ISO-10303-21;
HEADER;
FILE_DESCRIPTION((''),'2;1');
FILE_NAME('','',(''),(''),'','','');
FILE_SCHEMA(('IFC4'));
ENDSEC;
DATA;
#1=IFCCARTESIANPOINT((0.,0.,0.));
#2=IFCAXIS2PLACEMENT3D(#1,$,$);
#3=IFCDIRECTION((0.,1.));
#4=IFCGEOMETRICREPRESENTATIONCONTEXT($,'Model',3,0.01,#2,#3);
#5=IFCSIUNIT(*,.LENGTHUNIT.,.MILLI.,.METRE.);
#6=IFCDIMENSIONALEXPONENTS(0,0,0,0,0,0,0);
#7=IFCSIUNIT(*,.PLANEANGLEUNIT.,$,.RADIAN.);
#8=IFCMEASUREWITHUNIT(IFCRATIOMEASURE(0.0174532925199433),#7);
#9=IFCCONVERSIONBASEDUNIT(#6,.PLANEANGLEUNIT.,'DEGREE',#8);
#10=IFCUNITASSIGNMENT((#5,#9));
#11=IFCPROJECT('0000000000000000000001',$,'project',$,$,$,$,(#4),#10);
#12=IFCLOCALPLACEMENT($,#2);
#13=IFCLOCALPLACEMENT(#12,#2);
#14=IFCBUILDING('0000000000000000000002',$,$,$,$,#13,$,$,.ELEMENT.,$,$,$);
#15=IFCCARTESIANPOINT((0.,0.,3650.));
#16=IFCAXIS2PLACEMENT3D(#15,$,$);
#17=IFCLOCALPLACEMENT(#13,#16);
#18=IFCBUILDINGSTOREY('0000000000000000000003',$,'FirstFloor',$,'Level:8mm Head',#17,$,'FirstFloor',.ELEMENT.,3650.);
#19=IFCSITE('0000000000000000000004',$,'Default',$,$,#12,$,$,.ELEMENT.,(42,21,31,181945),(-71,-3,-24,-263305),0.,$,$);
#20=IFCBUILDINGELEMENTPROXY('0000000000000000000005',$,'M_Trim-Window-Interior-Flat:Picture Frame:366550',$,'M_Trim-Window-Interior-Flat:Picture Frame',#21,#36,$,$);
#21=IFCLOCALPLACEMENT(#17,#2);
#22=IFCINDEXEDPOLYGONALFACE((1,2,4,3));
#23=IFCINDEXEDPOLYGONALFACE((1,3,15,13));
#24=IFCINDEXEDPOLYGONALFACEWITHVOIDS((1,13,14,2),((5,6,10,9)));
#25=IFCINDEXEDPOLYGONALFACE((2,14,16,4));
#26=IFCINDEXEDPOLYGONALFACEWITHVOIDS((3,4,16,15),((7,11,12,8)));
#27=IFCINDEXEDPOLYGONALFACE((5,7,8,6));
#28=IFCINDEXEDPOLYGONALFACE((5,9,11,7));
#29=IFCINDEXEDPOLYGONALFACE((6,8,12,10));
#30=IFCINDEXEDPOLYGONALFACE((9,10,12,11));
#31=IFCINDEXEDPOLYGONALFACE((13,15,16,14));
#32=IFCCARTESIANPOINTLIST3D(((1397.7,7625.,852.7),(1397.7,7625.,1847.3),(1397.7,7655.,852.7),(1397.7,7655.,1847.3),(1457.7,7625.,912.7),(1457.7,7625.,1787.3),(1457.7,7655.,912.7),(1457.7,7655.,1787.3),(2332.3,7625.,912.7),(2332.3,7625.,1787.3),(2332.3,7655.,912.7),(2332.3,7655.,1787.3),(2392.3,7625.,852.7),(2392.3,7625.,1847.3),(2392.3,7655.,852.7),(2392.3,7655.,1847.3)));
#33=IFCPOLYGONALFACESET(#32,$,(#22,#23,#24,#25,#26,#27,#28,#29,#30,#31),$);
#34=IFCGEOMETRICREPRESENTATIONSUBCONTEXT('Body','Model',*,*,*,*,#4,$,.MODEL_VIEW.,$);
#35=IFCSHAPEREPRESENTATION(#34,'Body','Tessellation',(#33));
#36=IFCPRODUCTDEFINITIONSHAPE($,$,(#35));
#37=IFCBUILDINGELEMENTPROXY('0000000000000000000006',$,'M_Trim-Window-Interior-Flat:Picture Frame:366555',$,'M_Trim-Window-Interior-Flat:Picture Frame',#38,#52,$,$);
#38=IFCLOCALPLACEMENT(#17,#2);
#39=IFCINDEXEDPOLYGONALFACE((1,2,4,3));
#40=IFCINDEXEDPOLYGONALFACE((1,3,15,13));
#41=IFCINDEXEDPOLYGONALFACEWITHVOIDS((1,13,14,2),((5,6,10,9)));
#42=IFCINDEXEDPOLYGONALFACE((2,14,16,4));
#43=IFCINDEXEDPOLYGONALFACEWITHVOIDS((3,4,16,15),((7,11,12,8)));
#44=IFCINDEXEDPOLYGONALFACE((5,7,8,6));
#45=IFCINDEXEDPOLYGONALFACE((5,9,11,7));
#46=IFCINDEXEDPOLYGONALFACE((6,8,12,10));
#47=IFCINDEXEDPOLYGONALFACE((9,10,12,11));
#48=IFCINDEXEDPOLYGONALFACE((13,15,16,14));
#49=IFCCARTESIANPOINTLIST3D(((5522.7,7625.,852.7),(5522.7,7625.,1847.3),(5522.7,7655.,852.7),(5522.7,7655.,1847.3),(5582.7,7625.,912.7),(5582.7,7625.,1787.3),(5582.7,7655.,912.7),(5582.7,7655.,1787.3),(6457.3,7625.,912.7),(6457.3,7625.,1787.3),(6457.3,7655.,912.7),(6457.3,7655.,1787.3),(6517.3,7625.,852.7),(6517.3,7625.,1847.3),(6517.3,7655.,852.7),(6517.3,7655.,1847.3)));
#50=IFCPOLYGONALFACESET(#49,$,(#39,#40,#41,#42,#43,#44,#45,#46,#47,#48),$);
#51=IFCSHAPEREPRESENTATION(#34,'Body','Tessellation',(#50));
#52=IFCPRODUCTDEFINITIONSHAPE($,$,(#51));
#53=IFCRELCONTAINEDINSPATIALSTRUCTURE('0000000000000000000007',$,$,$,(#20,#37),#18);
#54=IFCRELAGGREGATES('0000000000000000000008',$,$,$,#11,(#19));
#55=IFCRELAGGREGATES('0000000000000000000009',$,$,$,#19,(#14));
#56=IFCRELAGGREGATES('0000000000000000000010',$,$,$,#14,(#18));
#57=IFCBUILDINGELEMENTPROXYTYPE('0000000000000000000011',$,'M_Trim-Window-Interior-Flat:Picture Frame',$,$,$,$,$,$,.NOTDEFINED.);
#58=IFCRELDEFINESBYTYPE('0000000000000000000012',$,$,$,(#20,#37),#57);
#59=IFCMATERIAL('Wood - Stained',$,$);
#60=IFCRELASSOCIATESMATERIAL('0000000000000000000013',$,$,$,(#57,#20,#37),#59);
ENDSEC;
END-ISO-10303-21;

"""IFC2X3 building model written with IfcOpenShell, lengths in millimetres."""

from ifc_helpers import new_model, entity, si_unit, converted_unit, direction, frame, origin, place, context, subcontext, project, spatial, polyline, outline, extrude, source, transform, mapped, material, type_object, type_shapes, element, save


model = new_model("IFC2X3")

# Units and contexts
model_context = context("Model", 3, precision=0.01, world=origin(), true_north=direction((0.0, 1.0)))
body_context = subcontext(model_context, "Body", "Model", "MODEL_VIEW")
ifc_project = project(units=[si_unit("LENGTHUNIT", "METRE", prefix="MILLI"), converted_unit("PLANEANGLEUNIT", "DEGREE", entity("IfcRatioMeasure", 0.0174532925199433), si_unit("PLANEANGLEUNIT", "RADIAN"), dimensions=[0, 0, 0, 0, 0, 0, 0])], contexts=[model_context])

# Site, building, storey
site_placement = place(None, origin())
site = spatial("IfcSite", under=ifc_project, at=site_placement, Name="Default", CompositionType="ELEMENT", RefLatitude=(42, 21, 31, 181945), RefLongitude=(-71, -3, -24, -263305), RefElevation=0.0)
building_placement = place(site_placement, origin())
building = spatial("IfcBuilding", under=site, at=building_placement, CompositionType="ELEMENT")
storey_placement = place(building_placement, frame((0.0, 0.0, 3650.0)))
storey = spatial("IfcBuildingStorey", under=building, at=storey_placement, Name="FirstFloor", ObjectType="Level:8mm Head", LongName="FirstFloor", CompositionType="ELEMENT", Elevation=3650.0)

# Shared definitions
ifc_material_1 = material(Name="Wood - Stained")

# Building element proxies
building_element_proxy_type_1 = type_object("IfcBuildingElementProxyType", Name="M_Trim-Window-Interior-Flat:Picture Frame", PredefinedType="NOTDEFINED", material=ifc_material_1)
shared_shape_1 = source(origin(), body_context, "Body", "SweptSolid", [
    extrude(outline(polyline([(-497.3, -497.3), (497.3, -497.3), (497.3, 497.3), (-497.3, 497.3), (-497.3, -497.3)]), holes=[polyline([(-437.3, -437.3), (-437.3, 437.3), (437.3, 437.3), (437.3, -437.3), (-437.3, -437.3)])]), frame((0.0, -450.0, 0.0), z_axis=(0.0, 0.0, 1.0), x_axis=(-1.0, 0.0, 0.0)), (0.0, 0.0, 1.0), 30.0),
])
type_shapes(building_element_proxy_type_1, [shared_shape_1])
for number, where, z_axis, x_axis, name in (
    (1, (1895.0, 7625.0, 1800.0), (0.0, 1.0, 0.0), (-1.0, 0.0, 0.0), "M_Trim-Window-Interior-Flat:Picture Frame:366550"),
    (2, (6020.0, 7625.0, 1800.0), (0.0, 1.0, 0.0), (-1.0, 0.0, 0.0), "M_Trim-Window-Interior-Flat:Picture Frame:366555"),
):
    element("IfcBuildingElementProxy", number, at=place(storey_placement, frame(where, z_axis=z_axis, x_axis=x_axis)), inside=storey, type_object=building_element_proxy_type_1, material=ifc_material_1, Name=name, ObjectType="M_Trim-Window-Interior-Flat:Picture Frame", context=body_context, shape_type="MappedRepresentation", body=[
        mapped(shared_shape_1, transform((0.0, 0.0, 0.0), scale=1.0)),
    ])

save(model, "model.ifc")
